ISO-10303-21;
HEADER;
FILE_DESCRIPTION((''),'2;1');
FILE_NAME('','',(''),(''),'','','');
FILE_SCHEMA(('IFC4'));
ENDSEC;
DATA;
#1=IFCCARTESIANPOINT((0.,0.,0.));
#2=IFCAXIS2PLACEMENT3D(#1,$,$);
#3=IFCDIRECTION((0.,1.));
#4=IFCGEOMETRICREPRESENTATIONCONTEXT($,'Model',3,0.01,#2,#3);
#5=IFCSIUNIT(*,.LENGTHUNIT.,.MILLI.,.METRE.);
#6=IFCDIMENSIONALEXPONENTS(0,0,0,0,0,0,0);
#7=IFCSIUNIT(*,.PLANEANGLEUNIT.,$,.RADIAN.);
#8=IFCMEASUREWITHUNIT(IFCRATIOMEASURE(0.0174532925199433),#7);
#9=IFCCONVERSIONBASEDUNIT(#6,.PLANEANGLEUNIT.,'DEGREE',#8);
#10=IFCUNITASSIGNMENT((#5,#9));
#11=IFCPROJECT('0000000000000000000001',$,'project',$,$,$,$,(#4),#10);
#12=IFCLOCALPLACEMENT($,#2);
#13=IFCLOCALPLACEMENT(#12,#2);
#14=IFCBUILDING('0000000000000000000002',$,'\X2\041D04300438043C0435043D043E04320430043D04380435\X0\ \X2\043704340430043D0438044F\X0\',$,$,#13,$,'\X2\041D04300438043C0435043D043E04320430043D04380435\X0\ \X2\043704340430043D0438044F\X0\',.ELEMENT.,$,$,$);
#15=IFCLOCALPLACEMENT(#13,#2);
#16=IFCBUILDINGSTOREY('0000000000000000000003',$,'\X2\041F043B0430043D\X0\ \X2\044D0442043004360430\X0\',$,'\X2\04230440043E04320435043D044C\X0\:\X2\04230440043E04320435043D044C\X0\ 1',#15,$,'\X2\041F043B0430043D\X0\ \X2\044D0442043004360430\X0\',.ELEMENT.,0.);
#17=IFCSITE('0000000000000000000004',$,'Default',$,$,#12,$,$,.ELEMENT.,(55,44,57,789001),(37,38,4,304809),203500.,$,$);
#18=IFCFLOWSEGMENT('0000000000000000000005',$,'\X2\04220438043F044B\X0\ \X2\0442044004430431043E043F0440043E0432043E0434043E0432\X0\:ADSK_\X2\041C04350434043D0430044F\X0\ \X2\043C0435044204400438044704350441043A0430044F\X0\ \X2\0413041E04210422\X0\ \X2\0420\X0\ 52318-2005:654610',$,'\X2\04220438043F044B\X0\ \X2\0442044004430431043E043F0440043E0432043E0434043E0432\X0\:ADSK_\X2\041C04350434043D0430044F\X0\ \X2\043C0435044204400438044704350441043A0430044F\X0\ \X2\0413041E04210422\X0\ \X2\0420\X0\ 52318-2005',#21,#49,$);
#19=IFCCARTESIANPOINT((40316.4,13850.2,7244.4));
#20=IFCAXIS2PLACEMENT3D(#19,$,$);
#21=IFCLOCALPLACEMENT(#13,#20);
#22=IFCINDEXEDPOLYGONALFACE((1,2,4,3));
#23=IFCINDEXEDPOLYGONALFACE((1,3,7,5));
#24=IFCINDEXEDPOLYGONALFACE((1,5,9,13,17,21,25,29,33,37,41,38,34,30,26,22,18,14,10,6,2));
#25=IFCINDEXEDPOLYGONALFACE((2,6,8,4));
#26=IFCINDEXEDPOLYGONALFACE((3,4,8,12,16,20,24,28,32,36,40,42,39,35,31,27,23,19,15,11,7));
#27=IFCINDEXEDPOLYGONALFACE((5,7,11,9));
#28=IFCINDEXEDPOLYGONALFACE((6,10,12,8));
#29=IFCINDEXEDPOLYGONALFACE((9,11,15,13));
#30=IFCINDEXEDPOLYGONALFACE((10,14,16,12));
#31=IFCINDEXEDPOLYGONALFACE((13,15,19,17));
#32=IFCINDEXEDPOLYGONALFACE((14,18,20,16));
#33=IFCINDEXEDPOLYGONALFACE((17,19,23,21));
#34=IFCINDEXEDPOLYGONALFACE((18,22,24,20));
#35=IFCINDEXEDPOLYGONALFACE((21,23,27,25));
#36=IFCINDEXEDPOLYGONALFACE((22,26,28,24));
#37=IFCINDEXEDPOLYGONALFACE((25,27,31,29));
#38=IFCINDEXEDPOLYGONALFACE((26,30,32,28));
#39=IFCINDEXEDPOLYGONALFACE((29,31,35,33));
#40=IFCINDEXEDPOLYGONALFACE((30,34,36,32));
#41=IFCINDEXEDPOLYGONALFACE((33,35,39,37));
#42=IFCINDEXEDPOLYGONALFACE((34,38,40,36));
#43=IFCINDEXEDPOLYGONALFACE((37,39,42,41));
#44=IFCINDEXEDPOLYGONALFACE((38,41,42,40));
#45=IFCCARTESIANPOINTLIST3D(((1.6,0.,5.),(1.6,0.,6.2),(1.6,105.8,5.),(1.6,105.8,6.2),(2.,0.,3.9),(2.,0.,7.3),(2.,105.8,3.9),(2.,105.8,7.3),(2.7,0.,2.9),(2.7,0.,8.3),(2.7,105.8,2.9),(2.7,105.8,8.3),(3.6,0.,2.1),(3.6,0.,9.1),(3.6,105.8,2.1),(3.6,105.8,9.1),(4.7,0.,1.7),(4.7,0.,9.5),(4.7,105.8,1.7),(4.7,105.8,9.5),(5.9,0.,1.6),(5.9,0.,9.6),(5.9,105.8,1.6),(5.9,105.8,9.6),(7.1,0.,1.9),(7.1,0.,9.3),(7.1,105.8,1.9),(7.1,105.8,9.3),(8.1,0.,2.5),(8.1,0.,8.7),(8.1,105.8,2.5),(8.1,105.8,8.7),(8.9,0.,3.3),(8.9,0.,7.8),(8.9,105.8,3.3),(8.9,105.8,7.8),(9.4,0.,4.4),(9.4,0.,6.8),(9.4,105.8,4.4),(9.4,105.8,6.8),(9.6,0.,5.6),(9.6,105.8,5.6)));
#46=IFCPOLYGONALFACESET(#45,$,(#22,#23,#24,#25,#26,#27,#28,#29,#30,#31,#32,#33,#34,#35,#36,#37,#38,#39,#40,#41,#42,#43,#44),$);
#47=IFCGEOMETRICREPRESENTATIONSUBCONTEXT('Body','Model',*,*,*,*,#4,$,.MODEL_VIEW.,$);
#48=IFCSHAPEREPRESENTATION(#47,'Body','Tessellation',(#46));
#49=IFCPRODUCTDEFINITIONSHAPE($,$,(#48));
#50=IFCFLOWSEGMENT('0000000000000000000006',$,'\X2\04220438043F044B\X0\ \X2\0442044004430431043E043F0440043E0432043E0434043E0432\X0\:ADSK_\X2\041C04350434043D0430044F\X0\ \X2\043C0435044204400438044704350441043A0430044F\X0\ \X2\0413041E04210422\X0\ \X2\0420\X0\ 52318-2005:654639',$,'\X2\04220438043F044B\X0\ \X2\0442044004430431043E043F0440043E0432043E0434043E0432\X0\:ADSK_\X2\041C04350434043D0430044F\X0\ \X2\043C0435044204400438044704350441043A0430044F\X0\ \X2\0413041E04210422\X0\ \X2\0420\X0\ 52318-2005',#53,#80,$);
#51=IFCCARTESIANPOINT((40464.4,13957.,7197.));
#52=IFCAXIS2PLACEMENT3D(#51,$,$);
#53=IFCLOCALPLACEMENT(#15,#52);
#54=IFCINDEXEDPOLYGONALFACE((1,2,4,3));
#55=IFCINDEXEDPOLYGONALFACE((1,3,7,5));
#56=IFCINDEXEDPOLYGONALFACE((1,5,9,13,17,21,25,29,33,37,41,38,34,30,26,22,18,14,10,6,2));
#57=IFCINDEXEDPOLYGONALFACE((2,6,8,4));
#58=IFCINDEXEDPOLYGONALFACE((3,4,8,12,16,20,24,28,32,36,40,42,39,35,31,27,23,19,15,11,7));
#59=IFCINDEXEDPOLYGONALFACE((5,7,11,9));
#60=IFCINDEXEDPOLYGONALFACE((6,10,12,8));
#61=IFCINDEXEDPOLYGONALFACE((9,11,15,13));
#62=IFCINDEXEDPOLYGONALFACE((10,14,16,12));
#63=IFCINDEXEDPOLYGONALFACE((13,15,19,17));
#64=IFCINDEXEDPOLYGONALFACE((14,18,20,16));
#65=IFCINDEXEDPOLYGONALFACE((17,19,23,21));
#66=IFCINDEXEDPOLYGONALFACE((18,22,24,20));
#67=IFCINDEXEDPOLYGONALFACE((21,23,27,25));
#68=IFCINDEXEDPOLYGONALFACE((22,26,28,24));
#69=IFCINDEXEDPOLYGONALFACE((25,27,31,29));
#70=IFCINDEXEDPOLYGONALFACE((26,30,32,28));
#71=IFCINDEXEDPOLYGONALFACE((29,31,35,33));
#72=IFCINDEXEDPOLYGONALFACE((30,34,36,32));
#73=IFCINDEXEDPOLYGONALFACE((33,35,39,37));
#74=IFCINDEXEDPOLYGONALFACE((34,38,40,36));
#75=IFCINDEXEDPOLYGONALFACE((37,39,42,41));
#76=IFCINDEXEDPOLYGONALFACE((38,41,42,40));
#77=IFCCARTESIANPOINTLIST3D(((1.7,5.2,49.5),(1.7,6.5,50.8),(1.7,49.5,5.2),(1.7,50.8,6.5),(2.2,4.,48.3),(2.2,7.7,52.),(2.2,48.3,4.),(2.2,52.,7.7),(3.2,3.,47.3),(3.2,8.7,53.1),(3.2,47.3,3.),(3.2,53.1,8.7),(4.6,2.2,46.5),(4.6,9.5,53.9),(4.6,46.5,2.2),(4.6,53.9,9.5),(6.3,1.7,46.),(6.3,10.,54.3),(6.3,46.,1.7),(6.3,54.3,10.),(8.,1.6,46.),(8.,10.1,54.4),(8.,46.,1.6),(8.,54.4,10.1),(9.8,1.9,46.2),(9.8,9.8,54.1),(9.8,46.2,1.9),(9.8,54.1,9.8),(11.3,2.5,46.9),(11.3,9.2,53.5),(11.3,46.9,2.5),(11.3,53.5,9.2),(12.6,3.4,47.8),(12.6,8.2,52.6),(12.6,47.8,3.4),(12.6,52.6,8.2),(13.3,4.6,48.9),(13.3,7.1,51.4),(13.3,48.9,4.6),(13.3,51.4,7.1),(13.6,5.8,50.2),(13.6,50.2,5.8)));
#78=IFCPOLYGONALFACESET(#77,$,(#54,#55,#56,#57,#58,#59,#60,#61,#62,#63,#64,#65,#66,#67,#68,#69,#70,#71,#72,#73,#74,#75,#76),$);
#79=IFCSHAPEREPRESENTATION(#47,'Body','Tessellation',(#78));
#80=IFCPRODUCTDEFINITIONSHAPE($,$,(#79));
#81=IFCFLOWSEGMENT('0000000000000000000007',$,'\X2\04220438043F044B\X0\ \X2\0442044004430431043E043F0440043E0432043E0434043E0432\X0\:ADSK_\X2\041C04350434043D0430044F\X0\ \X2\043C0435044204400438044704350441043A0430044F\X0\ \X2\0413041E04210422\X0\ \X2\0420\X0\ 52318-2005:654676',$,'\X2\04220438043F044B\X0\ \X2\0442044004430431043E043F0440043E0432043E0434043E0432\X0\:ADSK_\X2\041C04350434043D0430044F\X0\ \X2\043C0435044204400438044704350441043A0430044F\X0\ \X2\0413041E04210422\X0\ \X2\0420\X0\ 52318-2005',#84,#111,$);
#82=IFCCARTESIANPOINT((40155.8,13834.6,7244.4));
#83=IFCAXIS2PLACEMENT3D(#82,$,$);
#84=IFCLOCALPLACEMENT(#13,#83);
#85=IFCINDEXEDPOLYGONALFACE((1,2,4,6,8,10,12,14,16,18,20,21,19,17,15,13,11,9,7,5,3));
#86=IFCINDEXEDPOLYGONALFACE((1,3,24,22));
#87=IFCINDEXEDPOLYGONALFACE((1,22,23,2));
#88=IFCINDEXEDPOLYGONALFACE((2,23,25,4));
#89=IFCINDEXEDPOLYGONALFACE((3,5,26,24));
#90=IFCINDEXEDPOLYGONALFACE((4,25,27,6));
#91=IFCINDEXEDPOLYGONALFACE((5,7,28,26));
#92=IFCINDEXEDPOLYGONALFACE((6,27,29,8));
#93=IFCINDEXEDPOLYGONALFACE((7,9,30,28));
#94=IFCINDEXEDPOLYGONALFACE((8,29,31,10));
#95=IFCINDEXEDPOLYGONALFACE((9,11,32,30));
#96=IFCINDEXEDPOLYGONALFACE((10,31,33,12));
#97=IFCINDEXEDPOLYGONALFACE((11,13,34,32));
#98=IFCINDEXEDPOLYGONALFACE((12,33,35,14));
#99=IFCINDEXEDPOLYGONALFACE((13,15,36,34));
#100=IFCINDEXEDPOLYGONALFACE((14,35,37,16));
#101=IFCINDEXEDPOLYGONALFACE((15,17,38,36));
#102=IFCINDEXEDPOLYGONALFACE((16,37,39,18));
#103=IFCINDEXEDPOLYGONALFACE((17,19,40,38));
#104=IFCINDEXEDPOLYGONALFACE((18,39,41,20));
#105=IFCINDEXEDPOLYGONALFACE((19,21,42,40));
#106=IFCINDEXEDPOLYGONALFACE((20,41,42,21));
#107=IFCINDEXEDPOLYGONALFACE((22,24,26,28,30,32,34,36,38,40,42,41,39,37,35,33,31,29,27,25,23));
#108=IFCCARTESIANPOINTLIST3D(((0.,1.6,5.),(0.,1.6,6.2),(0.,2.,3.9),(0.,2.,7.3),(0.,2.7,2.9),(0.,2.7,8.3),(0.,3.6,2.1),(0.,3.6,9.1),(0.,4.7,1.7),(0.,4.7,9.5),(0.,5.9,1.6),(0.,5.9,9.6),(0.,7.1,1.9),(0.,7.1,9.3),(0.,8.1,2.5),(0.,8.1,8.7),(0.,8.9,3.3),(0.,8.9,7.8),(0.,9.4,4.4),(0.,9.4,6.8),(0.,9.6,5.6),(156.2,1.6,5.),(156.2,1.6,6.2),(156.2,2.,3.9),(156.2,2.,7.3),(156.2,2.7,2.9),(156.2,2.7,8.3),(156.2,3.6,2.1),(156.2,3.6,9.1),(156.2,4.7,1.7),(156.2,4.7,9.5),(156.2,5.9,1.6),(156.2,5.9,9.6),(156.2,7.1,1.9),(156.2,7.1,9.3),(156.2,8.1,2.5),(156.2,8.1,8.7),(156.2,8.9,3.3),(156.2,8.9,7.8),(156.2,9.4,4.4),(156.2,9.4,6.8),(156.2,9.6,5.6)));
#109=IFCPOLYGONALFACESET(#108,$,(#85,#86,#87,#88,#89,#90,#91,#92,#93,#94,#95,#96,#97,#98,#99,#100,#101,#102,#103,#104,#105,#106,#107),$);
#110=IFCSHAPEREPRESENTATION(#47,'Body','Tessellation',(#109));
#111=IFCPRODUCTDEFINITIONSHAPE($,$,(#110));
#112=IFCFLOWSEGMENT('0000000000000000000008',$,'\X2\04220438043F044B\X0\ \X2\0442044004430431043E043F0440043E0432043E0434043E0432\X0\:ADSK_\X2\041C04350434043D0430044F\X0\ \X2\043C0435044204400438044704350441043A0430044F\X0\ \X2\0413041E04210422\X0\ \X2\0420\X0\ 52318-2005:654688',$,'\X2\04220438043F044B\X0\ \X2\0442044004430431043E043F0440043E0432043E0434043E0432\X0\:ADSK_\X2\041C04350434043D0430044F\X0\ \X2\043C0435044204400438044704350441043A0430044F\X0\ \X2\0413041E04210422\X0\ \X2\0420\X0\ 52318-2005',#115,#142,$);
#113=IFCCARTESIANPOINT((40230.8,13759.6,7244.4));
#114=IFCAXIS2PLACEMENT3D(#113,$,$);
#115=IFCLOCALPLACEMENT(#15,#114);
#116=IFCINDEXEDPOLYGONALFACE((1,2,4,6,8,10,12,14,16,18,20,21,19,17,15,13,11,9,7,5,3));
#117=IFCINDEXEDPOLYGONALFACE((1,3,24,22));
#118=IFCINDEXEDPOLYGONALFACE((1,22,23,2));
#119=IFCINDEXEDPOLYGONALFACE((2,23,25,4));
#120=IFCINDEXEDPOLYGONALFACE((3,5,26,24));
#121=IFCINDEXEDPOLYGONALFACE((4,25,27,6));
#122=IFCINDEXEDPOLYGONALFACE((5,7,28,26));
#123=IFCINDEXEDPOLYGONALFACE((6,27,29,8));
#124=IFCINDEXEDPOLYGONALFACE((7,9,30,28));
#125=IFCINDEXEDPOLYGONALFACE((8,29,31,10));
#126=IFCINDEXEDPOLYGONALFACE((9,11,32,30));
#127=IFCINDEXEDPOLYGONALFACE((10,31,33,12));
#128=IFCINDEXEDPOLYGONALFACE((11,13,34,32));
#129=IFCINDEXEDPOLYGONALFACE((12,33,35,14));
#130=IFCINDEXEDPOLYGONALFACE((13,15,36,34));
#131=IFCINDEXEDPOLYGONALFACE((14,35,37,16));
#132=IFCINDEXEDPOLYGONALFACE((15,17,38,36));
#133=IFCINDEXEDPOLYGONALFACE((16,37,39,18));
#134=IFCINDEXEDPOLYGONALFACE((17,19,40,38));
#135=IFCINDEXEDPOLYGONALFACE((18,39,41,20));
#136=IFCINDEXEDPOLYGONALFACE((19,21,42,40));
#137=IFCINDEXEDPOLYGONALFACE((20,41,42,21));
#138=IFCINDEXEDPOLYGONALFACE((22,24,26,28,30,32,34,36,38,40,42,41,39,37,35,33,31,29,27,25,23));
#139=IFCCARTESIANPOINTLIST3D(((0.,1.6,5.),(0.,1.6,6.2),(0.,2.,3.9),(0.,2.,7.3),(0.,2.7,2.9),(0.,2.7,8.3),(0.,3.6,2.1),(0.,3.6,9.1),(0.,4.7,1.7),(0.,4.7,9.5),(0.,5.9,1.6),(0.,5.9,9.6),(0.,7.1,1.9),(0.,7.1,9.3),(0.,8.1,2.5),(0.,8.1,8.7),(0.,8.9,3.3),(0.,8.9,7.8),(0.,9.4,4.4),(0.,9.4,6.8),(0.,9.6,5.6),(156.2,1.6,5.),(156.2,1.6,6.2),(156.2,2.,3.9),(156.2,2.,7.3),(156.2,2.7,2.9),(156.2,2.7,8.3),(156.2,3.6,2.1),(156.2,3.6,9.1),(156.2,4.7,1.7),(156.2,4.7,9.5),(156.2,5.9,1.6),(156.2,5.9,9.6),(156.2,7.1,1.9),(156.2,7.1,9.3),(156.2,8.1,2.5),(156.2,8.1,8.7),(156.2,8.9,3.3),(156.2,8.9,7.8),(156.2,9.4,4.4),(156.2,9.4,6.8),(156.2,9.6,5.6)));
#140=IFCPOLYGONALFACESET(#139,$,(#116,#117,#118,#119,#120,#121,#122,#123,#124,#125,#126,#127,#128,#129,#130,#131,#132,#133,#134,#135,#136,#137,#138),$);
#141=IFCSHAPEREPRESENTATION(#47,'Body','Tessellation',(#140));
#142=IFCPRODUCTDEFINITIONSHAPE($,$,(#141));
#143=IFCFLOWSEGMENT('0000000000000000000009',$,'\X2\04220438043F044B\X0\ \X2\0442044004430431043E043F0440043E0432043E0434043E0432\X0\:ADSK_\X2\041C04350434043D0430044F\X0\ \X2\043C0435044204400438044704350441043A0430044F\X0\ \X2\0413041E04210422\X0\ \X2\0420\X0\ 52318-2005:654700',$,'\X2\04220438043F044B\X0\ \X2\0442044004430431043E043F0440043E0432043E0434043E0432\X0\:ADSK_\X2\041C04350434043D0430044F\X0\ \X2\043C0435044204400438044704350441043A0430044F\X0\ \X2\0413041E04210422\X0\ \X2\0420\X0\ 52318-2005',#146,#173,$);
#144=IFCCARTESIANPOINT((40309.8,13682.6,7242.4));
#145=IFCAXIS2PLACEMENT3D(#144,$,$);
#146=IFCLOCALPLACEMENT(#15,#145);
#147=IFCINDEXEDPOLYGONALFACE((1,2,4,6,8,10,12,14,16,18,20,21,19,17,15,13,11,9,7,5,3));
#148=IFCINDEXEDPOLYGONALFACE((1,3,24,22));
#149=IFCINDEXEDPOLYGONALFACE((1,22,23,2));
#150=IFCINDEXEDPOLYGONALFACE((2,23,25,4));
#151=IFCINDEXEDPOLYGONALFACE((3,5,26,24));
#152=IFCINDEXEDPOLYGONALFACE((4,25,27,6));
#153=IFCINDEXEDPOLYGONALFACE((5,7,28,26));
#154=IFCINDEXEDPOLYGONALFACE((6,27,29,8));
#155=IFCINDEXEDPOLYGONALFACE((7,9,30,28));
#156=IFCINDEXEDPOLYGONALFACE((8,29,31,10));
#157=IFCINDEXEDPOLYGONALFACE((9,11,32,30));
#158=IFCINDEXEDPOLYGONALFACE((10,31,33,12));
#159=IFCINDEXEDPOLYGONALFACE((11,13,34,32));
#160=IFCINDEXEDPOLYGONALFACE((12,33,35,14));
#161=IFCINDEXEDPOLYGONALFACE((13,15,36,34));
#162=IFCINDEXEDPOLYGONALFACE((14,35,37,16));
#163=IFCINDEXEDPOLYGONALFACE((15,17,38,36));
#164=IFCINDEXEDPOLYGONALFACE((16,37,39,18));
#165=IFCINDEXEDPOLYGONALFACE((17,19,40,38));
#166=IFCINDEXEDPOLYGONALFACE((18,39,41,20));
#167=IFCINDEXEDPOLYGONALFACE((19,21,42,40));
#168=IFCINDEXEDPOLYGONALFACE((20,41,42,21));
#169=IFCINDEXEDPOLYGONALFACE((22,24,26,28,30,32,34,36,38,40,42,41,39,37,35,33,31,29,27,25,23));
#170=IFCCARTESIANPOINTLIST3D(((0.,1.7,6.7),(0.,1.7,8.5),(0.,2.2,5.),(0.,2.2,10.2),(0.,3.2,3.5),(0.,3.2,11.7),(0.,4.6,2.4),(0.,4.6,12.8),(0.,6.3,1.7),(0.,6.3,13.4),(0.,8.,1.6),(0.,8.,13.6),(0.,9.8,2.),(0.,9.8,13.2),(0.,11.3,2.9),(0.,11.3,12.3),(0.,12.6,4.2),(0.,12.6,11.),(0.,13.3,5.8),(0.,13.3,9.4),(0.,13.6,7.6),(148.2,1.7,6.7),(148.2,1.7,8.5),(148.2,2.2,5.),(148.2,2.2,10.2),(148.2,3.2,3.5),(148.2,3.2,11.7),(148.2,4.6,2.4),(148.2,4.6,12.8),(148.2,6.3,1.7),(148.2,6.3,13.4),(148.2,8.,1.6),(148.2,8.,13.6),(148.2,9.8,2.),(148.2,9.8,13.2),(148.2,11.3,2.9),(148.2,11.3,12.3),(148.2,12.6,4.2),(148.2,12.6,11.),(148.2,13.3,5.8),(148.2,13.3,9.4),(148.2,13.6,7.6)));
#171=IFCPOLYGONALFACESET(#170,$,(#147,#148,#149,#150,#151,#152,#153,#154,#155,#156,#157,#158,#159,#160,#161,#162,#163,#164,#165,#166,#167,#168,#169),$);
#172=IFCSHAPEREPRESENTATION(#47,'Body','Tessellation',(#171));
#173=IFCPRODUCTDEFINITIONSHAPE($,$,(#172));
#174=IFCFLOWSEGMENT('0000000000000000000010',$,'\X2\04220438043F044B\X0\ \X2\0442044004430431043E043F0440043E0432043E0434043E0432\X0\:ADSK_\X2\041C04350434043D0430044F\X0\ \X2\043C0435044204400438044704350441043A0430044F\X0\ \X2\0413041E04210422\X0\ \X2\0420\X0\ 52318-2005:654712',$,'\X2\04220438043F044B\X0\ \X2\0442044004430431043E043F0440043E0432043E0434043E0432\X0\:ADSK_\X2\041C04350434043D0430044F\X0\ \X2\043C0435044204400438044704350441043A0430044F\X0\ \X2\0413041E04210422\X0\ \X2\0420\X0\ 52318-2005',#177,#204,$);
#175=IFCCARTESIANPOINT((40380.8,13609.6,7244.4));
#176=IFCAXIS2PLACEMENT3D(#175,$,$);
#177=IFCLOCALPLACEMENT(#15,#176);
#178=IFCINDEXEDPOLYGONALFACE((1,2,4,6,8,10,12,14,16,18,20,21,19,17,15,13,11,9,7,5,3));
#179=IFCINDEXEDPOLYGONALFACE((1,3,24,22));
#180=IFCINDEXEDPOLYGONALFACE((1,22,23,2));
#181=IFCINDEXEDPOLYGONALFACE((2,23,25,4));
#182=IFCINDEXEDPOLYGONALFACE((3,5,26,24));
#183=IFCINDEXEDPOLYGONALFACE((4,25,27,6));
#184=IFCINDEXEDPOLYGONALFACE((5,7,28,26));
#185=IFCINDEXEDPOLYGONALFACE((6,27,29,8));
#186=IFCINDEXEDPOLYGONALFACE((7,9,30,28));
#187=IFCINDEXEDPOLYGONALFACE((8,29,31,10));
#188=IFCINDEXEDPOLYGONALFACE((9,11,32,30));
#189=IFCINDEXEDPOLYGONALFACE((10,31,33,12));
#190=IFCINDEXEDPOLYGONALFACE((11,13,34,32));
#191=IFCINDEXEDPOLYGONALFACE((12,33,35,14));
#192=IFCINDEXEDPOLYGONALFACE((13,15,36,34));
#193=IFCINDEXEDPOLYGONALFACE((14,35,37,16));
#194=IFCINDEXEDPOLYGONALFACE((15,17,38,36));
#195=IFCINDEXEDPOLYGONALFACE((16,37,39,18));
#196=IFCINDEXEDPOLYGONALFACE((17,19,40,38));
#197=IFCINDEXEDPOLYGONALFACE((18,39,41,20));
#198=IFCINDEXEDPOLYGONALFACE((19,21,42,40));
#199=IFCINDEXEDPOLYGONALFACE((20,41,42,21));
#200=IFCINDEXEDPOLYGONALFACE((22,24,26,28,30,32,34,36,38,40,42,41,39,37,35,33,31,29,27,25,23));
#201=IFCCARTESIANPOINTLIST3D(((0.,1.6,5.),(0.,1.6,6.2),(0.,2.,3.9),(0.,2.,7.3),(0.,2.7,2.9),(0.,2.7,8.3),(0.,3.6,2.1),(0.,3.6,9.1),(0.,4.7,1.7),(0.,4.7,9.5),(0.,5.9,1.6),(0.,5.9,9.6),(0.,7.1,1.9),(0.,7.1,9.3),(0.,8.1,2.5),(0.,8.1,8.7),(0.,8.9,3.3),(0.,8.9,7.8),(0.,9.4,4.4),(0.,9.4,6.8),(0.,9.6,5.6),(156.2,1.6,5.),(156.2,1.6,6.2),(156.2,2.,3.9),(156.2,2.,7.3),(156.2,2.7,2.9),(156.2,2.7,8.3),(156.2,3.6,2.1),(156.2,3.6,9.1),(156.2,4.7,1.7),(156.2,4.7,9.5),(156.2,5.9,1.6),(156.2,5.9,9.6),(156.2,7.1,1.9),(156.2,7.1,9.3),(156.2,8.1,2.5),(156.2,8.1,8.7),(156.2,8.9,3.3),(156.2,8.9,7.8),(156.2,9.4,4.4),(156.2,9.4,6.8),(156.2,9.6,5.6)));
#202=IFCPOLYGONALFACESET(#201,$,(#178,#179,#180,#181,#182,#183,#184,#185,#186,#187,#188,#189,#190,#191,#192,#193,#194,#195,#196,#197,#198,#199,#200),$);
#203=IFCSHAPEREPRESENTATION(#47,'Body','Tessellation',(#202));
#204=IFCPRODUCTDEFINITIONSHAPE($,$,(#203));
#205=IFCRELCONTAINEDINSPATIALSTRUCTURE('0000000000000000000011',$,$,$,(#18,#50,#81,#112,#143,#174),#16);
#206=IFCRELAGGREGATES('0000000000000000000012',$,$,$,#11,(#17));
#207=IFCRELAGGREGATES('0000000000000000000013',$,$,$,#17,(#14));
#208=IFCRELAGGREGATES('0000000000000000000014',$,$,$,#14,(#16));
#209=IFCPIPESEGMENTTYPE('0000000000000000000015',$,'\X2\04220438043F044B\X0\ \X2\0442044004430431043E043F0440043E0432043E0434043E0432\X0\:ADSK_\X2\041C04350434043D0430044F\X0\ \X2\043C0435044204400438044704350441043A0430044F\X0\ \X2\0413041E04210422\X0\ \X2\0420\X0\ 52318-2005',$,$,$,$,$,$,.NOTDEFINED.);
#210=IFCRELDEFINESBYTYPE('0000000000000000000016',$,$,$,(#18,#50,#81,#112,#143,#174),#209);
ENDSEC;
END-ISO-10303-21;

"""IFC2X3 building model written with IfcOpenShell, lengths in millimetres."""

from ifc_helpers import new_model, entity, si_unit, converted_unit, direction, frame, frame_2d, origin, origin_2d_with_axis, place, context, subcontext, project, spatial, circle, extrude, type_object, element, save


model = new_model("IFC2X3")

# Units and contexts
model_context = context("Model", 3, precision=0.01, world=origin(), true_north=direction((0.0, 1.0)))
body_context = subcontext(model_context, "Body", "Model", "MODEL_VIEW")
ifc_project = project(units=[si_unit("LENGTHUNIT", "METRE", prefix="MILLI"), converted_unit("PLANEANGLEUNIT", "DEGREE", entity("IfcRatioMeasure", 0.0174532925199433), si_unit("PLANEANGLEUNIT", "RADIAN"), dimensions=[0, 0, 0, 0, 0, 0, 0])], contexts=[model_context])

# Site, building, storey
site_placement = place(None, frame((0.0, 0.0, 0.0)))
site = spatial("IfcSite", under=ifc_project, at=site_placement, Name="Default", CompositionType="ELEMENT", RefLatitude=(55, 44, 57, 789001), RefLongitude=(37, 38, 4, 304809), RefElevation=203500.0)
building_placement = place(site_placement, origin())
building = spatial("IfcBuilding", under=site, at=building_placement, Name="Наименование здания", LongName="Наименование здания", CompositionType="ELEMENT")
storey_placement = place(building_placement, origin())
storey = spatial("IfcBuildingStorey", under=building, at=storey_placement, Name="План этажа", ObjectType="Уровень:Уровень 1", LongName="План этажа", CompositionType="ELEMENT", Elevation=0.0)

# Flow segments
pipe_segment_type = type_object("IfcPipeSegmentType", Name="Типы трубопроводов:ADSK_Медная метрическая ГОСТ Р 52318-2005", PredefinedType="NOTDEFINED")
flow_segment_1_placement = place(building_placement, frame((40316.4, 13850.2, 7244.4)))
element("IfcFlowSegment", 1, at=flow_segment_1_placement, inside=storey, type_object=pipe_segment_type, Name="Типы трубопроводов:ADSK_Медная метрическая ГОСТ Р 52318-2005:654610", ObjectType="Типы трубопроводов:ADSK_Медная метрическая ГОСТ Р 52318-2005", context=body_context, shape_type="SweptSolid", body=[
    extrude(circle(Radius=4.0, at=origin_2d_with_axis()), frame((5.6, 0.0, 5.6), z_axis=(0.0, 1.0, 0.0), x_axis=(1.0, 0.0, 0.0)), (0.0, 0.0, 1.0), 105.8),
])
flow_segment_2_placement = place(storey_placement, frame((40464.4, 13957.0, 7197.0)))
element("IfcFlowSegment", 2, at=flow_segment_2_placement, inside=storey, type_object=pipe_segment_type, Name="Типы трубопроводов:ADSK_Медная метрическая ГОСТ Р 52318-2005:654639", ObjectType="Типы трубопроводов:ADSK_Медная метрическая ГОСТ Р 52318-2005", context=body_context, shape_type="SweptSolid", body=[
    extrude(circle(Radius=6.0, at=frame_2d((0.0, 0.0), x_axis=(1.0, 0.0))), frame((7.6, 50.2, 5.8), z_axis=(0.0, -0.707107, 0.707107), x_axis=(1.0, 0.0, 0.0)), (0.0, 0.0, 1.0), 62.7),
])
flow_segment_3_placement = place(building_placement, frame((40155.8, 13834.6, 7244.4)))
element("IfcFlowSegment", 3, at=flow_segment_3_placement, inside=storey, type_object=pipe_segment_type, Name="Типы трубопроводов:ADSK_Медная метрическая ГОСТ Р 52318-2005:654676", ObjectType="Типы трубопроводов:ADSK_Медная метрическая ГОСТ Р 52318-2005", context=body_context, shape_type="SweptSolid", body=[
    extrude(circle(Radius=4.0, at=frame_2d((0.0, 0.0), x_axis=(1.0, 0.0))), frame((0.0, 5.6, 5.6), z_axis=(1.0, 0.0, 0.0), x_axis=(0.0, 1.0, 0.0)), (0.0, 0.0, 1.0), 156.2),
])
flow_segment_4_placement = place(storey_placement, frame((40230.8, 13759.6, 7244.4)))
element("IfcFlowSegment", 4, at=flow_segment_4_placement, inside=storey, type_object=pipe_segment_type, Name="Типы трубопроводов:ADSK_Медная метрическая ГОСТ Р 52318-2005:654688", ObjectType="Типы трубопроводов:ADSK_Медная метрическая ГОСТ Р 52318-2005", context=body_context, shape_type="SweptSolid", body=[
    extrude(circle(Radius=4.0, at=frame_2d((0.0, 0.0), x_axis=(1.0, 0.0))), frame((0.0, 5.6, 5.6), z_axis=(1.0, 0.0, 0.0), x_axis=(0.0, 1.0, 0.0)), (0.0, 0.0, 1.0), 156.2),
])
flow_segment_5_placement = place(storey_placement, frame((40309.8, 13682.6, 7242.4)))
element("IfcFlowSegment", 5, at=flow_segment_5_placement, inside=storey, type_object=pipe_segment_type, Name="Типы трубопроводов:ADSK_Медная метрическая ГОСТ Р 52318-2005:654700", ObjectType="Типы трубопроводов:ADSK_Медная метрическая ГОСТ Р 52318-2005", context=body_context, shape_type="SweptSolid", body=[
    extrude(circle(Radius=6.0, at=frame_2d((0.0, 0.0), x_axis=(1.0, 0.0))), frame((0.0, 7.6, 7.6), z_axis=(1.0, 0.0, 0.0), x_axis=(0.0, 1.0, 0.0)), (0.0, 0.0, 1.0), 148.2),
])
flow_segment_6_placement = place(storey_placement, frame((40380.8, 13609.6, 7244.4)))
element("IfcFlowSegment", 6, at=flow_segment_6_placement, inside=storey, type_object=pipe_segment_type, Name="Типы трубопроводов:ADSK_Медная метрическая ГОСТ Р 52318-2005:654712", ObjectType="Типы трубопроводов:ADSK_Медная метрическая ГОСТ Р 52318-2005", context=body_context, shape_type="SweptSolid", body=[
    extrude(circle(Radius=4.0, at=frame_2d((0.0, 0.0), x_axis=(1.0, 0.0))), frame((0.0, 5.6, 5.6), z_axis=(1.0, 0.0, 0.0), x_axis=(0.0, 1.0, 0.0)), (0.0, 0.0, 1.0), 156.2),
])

save(model, "model.ifc")
